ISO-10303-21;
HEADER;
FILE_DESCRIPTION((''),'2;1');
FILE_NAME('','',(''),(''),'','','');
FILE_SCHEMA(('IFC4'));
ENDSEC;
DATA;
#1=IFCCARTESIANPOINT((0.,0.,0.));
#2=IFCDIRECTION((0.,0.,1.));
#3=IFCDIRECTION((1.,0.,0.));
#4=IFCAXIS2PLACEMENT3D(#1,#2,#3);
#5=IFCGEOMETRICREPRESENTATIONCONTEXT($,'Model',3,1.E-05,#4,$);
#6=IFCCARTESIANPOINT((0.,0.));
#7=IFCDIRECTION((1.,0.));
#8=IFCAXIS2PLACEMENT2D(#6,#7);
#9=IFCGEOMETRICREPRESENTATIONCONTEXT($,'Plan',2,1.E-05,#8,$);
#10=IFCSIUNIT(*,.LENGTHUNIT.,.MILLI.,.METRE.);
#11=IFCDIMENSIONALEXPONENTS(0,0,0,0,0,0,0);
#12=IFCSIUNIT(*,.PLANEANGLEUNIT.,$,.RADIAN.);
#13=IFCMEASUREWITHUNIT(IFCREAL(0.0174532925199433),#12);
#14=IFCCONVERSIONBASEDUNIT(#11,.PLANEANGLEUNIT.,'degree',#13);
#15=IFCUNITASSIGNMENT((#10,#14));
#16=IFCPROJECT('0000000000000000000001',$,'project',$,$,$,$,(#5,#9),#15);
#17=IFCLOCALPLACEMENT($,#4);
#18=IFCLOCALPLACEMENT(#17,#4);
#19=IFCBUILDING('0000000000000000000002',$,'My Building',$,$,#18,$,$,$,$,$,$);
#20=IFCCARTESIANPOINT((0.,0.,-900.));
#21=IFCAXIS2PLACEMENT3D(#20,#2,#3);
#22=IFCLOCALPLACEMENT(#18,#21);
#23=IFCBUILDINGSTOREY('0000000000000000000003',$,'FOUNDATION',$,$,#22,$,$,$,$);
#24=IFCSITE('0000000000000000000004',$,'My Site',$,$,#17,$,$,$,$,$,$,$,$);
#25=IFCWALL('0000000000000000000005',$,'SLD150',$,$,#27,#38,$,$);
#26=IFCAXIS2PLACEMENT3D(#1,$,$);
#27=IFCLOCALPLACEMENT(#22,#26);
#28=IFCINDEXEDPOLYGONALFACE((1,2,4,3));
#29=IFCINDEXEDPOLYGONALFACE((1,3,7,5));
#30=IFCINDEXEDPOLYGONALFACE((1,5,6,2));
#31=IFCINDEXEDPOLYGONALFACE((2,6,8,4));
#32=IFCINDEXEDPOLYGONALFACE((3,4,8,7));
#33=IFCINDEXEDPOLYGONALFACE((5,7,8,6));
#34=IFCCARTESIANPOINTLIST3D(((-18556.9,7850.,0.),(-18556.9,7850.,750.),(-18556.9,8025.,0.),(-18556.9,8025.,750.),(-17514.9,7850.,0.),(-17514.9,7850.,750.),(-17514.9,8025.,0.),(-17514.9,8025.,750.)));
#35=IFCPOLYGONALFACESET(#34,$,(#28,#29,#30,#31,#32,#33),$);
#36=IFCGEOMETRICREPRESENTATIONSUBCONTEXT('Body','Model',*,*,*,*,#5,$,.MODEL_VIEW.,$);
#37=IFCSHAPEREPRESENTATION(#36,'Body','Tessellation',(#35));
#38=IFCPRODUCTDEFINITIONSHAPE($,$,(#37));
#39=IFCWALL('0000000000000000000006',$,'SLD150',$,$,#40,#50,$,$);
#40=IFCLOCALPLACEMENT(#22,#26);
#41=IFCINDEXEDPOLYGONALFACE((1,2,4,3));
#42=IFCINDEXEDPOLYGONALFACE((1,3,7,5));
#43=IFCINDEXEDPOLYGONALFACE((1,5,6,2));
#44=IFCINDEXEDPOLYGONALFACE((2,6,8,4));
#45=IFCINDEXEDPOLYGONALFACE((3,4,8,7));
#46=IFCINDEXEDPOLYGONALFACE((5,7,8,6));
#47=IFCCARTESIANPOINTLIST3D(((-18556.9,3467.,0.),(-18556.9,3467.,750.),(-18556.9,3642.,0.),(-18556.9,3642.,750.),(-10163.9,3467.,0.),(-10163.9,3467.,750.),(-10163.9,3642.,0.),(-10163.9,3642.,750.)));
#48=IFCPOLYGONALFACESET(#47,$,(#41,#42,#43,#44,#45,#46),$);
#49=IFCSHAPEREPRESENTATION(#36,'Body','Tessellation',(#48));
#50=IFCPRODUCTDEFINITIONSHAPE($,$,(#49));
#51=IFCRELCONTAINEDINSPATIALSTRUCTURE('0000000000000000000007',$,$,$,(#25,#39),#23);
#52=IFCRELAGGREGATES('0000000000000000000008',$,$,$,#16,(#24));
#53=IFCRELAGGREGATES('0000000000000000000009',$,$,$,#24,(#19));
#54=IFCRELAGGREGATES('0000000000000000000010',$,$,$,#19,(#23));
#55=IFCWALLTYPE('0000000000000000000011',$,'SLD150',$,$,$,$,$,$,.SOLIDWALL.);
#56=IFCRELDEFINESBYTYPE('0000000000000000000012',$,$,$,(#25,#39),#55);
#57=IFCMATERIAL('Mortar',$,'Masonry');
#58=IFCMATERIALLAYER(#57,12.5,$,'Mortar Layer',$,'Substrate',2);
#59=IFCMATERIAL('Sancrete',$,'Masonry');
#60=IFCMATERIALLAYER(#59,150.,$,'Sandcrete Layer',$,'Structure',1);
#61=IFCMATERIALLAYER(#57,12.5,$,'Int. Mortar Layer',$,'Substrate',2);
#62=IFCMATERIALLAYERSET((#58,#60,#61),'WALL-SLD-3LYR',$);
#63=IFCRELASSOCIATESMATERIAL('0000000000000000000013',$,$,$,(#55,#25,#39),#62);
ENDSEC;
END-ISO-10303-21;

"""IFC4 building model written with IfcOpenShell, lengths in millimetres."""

from ifc_helpers import new_model, entity, si_unit, converted_unit, frame, origin_with_axes, origin_2d_with_axis, place, context, subcontext, project, spatial, indexed_curve, outline, extrude, material, layer, layer_set, layer_usage, type_object, element, save


model = new_model("IFC4")

# Units and contexts
model_context = context("Model", 3, precision=1e-05, world=origin_with_axes())
plan_context = context("Plan", 2, precision=1e-05, world=origin_2d_with_axis())
body_context = subcontext(model_context, "Body", "Model", "MODEL_VIEW")
ifc_project = project(units=[si_unit("LENGTHUNIT", "METRE", prefix="MILLI"), converted_unit("PLANEANGLEUNIT", "degree", entity("IfcReal", 0.0174532925199433), si_unit("PLANEANGLEUNIT", "RADIAN"), dimensions=[0, 0, 0, 0, 0, 0, 0])], contexts=[model_context, plan_context])

# Site, building, storey
site_placement = place(None, origin_with_axes())
site = spatial("IfcSite", under=ifc_project, at=site_placement, Name="My Site")
building_placement = place(site_placement, origin_with_axes())
building = spatial("IfcBuilding", under=site, at=building_placement, Name="My Building")
storey_placement = place(building_placement, frame((0.0, 0.0, -900.0), z_axis=(0.0, 0.0, 1.0), x_axis=(1.0, 0.0, 0.0)))
storey = spatial("IfcBuildingStorey", under=building, at=storey_placement, Name="FOUNDATION")

# Walls
ifc_material_1 = material(Name="Mortar", Category="Masonry")
ifc_layer_1 = layer(ifc_material_1, 12.5, Name="Mortar Layer", Category="Substrate", Priority=2)
ifc_material_2 = material(Name="Sancrete", Category="Masonry")
ifc_layer_2 = layer(ifc_material_2, 150.0, Name="Sandcrete Layer", Category="Structure", Priority=1)
ifc_layer_3 = layer(ifc_material_1, 12.5, Name="Int. Mortar Layer", Category="Substrate", Priority=2)
ifc_layer_set_1 = layer_set([ifc_layer_1, ifc_layer_2, ifc_layer_3], Name="WALL-SLD-3LYR")
wall_type_1 = type_object("IfcWallType", Name="SLD150", PredefinedType="SOLIDWALL", material=ifc_layer_set_1)
ifc_layer_usage_1 = layer_usage(ifc_layer_set_1, "AXIS2", "POSITIVE", 0.0)
wall_1_placement = place(storey_placement, frame((-17514.9, 8025.0, 0.0), z_axis=(0.0, 0.0, 1.0), x_axis=(-1.0, 0.0, 0.0)))
element("IfcWall", 1, at=wall_1_placement, inside=storey, type_object=wall_type_1, material=ifc_layer_usage_1, Name="SLD150", context=body_context, shape_type="SweptSolid", body=[
    extrude(outline(indexed_curve([(0.0, 0.0), (0.0, 175.0), (1042.0, 175.0), (1042.0, 0.0), (0.0, 0.0)], self_intersect=False)), origin_with_axes(), (0.0, 0.0, 1.0), 750.0),
])
ifc_layer_usage_2 = layer_usage(ifc_layer_set_1, "AXIS2", "POSITIVE", 0.0)
wall_2_placement = place(storey_placement, frame((-10163.9, 3642.0, 0.0), z_axis=(0.0, 0.0, 1.0), x_axis=(-1.0, 0.000001, 0.0)))
element("IfcWall", 2, at=wall_2_placement, inside=storey, type_object=wall_type_1, material=ifc_layer_usage_2, Name="SLD150", context=body_context, shape_type="SweptSolid", body=[
    extrude(outline(indexed_curve([(0.0, 0.0), (0.0, 175.0), (8393.0, 175.0), (8393.0, 0.0), (0.0, 0.0)], self_intersect=False)), origin_with_axes(), (0.0, 0.0, 1.0), 750.0),
])

save(model, "model.ifc")
